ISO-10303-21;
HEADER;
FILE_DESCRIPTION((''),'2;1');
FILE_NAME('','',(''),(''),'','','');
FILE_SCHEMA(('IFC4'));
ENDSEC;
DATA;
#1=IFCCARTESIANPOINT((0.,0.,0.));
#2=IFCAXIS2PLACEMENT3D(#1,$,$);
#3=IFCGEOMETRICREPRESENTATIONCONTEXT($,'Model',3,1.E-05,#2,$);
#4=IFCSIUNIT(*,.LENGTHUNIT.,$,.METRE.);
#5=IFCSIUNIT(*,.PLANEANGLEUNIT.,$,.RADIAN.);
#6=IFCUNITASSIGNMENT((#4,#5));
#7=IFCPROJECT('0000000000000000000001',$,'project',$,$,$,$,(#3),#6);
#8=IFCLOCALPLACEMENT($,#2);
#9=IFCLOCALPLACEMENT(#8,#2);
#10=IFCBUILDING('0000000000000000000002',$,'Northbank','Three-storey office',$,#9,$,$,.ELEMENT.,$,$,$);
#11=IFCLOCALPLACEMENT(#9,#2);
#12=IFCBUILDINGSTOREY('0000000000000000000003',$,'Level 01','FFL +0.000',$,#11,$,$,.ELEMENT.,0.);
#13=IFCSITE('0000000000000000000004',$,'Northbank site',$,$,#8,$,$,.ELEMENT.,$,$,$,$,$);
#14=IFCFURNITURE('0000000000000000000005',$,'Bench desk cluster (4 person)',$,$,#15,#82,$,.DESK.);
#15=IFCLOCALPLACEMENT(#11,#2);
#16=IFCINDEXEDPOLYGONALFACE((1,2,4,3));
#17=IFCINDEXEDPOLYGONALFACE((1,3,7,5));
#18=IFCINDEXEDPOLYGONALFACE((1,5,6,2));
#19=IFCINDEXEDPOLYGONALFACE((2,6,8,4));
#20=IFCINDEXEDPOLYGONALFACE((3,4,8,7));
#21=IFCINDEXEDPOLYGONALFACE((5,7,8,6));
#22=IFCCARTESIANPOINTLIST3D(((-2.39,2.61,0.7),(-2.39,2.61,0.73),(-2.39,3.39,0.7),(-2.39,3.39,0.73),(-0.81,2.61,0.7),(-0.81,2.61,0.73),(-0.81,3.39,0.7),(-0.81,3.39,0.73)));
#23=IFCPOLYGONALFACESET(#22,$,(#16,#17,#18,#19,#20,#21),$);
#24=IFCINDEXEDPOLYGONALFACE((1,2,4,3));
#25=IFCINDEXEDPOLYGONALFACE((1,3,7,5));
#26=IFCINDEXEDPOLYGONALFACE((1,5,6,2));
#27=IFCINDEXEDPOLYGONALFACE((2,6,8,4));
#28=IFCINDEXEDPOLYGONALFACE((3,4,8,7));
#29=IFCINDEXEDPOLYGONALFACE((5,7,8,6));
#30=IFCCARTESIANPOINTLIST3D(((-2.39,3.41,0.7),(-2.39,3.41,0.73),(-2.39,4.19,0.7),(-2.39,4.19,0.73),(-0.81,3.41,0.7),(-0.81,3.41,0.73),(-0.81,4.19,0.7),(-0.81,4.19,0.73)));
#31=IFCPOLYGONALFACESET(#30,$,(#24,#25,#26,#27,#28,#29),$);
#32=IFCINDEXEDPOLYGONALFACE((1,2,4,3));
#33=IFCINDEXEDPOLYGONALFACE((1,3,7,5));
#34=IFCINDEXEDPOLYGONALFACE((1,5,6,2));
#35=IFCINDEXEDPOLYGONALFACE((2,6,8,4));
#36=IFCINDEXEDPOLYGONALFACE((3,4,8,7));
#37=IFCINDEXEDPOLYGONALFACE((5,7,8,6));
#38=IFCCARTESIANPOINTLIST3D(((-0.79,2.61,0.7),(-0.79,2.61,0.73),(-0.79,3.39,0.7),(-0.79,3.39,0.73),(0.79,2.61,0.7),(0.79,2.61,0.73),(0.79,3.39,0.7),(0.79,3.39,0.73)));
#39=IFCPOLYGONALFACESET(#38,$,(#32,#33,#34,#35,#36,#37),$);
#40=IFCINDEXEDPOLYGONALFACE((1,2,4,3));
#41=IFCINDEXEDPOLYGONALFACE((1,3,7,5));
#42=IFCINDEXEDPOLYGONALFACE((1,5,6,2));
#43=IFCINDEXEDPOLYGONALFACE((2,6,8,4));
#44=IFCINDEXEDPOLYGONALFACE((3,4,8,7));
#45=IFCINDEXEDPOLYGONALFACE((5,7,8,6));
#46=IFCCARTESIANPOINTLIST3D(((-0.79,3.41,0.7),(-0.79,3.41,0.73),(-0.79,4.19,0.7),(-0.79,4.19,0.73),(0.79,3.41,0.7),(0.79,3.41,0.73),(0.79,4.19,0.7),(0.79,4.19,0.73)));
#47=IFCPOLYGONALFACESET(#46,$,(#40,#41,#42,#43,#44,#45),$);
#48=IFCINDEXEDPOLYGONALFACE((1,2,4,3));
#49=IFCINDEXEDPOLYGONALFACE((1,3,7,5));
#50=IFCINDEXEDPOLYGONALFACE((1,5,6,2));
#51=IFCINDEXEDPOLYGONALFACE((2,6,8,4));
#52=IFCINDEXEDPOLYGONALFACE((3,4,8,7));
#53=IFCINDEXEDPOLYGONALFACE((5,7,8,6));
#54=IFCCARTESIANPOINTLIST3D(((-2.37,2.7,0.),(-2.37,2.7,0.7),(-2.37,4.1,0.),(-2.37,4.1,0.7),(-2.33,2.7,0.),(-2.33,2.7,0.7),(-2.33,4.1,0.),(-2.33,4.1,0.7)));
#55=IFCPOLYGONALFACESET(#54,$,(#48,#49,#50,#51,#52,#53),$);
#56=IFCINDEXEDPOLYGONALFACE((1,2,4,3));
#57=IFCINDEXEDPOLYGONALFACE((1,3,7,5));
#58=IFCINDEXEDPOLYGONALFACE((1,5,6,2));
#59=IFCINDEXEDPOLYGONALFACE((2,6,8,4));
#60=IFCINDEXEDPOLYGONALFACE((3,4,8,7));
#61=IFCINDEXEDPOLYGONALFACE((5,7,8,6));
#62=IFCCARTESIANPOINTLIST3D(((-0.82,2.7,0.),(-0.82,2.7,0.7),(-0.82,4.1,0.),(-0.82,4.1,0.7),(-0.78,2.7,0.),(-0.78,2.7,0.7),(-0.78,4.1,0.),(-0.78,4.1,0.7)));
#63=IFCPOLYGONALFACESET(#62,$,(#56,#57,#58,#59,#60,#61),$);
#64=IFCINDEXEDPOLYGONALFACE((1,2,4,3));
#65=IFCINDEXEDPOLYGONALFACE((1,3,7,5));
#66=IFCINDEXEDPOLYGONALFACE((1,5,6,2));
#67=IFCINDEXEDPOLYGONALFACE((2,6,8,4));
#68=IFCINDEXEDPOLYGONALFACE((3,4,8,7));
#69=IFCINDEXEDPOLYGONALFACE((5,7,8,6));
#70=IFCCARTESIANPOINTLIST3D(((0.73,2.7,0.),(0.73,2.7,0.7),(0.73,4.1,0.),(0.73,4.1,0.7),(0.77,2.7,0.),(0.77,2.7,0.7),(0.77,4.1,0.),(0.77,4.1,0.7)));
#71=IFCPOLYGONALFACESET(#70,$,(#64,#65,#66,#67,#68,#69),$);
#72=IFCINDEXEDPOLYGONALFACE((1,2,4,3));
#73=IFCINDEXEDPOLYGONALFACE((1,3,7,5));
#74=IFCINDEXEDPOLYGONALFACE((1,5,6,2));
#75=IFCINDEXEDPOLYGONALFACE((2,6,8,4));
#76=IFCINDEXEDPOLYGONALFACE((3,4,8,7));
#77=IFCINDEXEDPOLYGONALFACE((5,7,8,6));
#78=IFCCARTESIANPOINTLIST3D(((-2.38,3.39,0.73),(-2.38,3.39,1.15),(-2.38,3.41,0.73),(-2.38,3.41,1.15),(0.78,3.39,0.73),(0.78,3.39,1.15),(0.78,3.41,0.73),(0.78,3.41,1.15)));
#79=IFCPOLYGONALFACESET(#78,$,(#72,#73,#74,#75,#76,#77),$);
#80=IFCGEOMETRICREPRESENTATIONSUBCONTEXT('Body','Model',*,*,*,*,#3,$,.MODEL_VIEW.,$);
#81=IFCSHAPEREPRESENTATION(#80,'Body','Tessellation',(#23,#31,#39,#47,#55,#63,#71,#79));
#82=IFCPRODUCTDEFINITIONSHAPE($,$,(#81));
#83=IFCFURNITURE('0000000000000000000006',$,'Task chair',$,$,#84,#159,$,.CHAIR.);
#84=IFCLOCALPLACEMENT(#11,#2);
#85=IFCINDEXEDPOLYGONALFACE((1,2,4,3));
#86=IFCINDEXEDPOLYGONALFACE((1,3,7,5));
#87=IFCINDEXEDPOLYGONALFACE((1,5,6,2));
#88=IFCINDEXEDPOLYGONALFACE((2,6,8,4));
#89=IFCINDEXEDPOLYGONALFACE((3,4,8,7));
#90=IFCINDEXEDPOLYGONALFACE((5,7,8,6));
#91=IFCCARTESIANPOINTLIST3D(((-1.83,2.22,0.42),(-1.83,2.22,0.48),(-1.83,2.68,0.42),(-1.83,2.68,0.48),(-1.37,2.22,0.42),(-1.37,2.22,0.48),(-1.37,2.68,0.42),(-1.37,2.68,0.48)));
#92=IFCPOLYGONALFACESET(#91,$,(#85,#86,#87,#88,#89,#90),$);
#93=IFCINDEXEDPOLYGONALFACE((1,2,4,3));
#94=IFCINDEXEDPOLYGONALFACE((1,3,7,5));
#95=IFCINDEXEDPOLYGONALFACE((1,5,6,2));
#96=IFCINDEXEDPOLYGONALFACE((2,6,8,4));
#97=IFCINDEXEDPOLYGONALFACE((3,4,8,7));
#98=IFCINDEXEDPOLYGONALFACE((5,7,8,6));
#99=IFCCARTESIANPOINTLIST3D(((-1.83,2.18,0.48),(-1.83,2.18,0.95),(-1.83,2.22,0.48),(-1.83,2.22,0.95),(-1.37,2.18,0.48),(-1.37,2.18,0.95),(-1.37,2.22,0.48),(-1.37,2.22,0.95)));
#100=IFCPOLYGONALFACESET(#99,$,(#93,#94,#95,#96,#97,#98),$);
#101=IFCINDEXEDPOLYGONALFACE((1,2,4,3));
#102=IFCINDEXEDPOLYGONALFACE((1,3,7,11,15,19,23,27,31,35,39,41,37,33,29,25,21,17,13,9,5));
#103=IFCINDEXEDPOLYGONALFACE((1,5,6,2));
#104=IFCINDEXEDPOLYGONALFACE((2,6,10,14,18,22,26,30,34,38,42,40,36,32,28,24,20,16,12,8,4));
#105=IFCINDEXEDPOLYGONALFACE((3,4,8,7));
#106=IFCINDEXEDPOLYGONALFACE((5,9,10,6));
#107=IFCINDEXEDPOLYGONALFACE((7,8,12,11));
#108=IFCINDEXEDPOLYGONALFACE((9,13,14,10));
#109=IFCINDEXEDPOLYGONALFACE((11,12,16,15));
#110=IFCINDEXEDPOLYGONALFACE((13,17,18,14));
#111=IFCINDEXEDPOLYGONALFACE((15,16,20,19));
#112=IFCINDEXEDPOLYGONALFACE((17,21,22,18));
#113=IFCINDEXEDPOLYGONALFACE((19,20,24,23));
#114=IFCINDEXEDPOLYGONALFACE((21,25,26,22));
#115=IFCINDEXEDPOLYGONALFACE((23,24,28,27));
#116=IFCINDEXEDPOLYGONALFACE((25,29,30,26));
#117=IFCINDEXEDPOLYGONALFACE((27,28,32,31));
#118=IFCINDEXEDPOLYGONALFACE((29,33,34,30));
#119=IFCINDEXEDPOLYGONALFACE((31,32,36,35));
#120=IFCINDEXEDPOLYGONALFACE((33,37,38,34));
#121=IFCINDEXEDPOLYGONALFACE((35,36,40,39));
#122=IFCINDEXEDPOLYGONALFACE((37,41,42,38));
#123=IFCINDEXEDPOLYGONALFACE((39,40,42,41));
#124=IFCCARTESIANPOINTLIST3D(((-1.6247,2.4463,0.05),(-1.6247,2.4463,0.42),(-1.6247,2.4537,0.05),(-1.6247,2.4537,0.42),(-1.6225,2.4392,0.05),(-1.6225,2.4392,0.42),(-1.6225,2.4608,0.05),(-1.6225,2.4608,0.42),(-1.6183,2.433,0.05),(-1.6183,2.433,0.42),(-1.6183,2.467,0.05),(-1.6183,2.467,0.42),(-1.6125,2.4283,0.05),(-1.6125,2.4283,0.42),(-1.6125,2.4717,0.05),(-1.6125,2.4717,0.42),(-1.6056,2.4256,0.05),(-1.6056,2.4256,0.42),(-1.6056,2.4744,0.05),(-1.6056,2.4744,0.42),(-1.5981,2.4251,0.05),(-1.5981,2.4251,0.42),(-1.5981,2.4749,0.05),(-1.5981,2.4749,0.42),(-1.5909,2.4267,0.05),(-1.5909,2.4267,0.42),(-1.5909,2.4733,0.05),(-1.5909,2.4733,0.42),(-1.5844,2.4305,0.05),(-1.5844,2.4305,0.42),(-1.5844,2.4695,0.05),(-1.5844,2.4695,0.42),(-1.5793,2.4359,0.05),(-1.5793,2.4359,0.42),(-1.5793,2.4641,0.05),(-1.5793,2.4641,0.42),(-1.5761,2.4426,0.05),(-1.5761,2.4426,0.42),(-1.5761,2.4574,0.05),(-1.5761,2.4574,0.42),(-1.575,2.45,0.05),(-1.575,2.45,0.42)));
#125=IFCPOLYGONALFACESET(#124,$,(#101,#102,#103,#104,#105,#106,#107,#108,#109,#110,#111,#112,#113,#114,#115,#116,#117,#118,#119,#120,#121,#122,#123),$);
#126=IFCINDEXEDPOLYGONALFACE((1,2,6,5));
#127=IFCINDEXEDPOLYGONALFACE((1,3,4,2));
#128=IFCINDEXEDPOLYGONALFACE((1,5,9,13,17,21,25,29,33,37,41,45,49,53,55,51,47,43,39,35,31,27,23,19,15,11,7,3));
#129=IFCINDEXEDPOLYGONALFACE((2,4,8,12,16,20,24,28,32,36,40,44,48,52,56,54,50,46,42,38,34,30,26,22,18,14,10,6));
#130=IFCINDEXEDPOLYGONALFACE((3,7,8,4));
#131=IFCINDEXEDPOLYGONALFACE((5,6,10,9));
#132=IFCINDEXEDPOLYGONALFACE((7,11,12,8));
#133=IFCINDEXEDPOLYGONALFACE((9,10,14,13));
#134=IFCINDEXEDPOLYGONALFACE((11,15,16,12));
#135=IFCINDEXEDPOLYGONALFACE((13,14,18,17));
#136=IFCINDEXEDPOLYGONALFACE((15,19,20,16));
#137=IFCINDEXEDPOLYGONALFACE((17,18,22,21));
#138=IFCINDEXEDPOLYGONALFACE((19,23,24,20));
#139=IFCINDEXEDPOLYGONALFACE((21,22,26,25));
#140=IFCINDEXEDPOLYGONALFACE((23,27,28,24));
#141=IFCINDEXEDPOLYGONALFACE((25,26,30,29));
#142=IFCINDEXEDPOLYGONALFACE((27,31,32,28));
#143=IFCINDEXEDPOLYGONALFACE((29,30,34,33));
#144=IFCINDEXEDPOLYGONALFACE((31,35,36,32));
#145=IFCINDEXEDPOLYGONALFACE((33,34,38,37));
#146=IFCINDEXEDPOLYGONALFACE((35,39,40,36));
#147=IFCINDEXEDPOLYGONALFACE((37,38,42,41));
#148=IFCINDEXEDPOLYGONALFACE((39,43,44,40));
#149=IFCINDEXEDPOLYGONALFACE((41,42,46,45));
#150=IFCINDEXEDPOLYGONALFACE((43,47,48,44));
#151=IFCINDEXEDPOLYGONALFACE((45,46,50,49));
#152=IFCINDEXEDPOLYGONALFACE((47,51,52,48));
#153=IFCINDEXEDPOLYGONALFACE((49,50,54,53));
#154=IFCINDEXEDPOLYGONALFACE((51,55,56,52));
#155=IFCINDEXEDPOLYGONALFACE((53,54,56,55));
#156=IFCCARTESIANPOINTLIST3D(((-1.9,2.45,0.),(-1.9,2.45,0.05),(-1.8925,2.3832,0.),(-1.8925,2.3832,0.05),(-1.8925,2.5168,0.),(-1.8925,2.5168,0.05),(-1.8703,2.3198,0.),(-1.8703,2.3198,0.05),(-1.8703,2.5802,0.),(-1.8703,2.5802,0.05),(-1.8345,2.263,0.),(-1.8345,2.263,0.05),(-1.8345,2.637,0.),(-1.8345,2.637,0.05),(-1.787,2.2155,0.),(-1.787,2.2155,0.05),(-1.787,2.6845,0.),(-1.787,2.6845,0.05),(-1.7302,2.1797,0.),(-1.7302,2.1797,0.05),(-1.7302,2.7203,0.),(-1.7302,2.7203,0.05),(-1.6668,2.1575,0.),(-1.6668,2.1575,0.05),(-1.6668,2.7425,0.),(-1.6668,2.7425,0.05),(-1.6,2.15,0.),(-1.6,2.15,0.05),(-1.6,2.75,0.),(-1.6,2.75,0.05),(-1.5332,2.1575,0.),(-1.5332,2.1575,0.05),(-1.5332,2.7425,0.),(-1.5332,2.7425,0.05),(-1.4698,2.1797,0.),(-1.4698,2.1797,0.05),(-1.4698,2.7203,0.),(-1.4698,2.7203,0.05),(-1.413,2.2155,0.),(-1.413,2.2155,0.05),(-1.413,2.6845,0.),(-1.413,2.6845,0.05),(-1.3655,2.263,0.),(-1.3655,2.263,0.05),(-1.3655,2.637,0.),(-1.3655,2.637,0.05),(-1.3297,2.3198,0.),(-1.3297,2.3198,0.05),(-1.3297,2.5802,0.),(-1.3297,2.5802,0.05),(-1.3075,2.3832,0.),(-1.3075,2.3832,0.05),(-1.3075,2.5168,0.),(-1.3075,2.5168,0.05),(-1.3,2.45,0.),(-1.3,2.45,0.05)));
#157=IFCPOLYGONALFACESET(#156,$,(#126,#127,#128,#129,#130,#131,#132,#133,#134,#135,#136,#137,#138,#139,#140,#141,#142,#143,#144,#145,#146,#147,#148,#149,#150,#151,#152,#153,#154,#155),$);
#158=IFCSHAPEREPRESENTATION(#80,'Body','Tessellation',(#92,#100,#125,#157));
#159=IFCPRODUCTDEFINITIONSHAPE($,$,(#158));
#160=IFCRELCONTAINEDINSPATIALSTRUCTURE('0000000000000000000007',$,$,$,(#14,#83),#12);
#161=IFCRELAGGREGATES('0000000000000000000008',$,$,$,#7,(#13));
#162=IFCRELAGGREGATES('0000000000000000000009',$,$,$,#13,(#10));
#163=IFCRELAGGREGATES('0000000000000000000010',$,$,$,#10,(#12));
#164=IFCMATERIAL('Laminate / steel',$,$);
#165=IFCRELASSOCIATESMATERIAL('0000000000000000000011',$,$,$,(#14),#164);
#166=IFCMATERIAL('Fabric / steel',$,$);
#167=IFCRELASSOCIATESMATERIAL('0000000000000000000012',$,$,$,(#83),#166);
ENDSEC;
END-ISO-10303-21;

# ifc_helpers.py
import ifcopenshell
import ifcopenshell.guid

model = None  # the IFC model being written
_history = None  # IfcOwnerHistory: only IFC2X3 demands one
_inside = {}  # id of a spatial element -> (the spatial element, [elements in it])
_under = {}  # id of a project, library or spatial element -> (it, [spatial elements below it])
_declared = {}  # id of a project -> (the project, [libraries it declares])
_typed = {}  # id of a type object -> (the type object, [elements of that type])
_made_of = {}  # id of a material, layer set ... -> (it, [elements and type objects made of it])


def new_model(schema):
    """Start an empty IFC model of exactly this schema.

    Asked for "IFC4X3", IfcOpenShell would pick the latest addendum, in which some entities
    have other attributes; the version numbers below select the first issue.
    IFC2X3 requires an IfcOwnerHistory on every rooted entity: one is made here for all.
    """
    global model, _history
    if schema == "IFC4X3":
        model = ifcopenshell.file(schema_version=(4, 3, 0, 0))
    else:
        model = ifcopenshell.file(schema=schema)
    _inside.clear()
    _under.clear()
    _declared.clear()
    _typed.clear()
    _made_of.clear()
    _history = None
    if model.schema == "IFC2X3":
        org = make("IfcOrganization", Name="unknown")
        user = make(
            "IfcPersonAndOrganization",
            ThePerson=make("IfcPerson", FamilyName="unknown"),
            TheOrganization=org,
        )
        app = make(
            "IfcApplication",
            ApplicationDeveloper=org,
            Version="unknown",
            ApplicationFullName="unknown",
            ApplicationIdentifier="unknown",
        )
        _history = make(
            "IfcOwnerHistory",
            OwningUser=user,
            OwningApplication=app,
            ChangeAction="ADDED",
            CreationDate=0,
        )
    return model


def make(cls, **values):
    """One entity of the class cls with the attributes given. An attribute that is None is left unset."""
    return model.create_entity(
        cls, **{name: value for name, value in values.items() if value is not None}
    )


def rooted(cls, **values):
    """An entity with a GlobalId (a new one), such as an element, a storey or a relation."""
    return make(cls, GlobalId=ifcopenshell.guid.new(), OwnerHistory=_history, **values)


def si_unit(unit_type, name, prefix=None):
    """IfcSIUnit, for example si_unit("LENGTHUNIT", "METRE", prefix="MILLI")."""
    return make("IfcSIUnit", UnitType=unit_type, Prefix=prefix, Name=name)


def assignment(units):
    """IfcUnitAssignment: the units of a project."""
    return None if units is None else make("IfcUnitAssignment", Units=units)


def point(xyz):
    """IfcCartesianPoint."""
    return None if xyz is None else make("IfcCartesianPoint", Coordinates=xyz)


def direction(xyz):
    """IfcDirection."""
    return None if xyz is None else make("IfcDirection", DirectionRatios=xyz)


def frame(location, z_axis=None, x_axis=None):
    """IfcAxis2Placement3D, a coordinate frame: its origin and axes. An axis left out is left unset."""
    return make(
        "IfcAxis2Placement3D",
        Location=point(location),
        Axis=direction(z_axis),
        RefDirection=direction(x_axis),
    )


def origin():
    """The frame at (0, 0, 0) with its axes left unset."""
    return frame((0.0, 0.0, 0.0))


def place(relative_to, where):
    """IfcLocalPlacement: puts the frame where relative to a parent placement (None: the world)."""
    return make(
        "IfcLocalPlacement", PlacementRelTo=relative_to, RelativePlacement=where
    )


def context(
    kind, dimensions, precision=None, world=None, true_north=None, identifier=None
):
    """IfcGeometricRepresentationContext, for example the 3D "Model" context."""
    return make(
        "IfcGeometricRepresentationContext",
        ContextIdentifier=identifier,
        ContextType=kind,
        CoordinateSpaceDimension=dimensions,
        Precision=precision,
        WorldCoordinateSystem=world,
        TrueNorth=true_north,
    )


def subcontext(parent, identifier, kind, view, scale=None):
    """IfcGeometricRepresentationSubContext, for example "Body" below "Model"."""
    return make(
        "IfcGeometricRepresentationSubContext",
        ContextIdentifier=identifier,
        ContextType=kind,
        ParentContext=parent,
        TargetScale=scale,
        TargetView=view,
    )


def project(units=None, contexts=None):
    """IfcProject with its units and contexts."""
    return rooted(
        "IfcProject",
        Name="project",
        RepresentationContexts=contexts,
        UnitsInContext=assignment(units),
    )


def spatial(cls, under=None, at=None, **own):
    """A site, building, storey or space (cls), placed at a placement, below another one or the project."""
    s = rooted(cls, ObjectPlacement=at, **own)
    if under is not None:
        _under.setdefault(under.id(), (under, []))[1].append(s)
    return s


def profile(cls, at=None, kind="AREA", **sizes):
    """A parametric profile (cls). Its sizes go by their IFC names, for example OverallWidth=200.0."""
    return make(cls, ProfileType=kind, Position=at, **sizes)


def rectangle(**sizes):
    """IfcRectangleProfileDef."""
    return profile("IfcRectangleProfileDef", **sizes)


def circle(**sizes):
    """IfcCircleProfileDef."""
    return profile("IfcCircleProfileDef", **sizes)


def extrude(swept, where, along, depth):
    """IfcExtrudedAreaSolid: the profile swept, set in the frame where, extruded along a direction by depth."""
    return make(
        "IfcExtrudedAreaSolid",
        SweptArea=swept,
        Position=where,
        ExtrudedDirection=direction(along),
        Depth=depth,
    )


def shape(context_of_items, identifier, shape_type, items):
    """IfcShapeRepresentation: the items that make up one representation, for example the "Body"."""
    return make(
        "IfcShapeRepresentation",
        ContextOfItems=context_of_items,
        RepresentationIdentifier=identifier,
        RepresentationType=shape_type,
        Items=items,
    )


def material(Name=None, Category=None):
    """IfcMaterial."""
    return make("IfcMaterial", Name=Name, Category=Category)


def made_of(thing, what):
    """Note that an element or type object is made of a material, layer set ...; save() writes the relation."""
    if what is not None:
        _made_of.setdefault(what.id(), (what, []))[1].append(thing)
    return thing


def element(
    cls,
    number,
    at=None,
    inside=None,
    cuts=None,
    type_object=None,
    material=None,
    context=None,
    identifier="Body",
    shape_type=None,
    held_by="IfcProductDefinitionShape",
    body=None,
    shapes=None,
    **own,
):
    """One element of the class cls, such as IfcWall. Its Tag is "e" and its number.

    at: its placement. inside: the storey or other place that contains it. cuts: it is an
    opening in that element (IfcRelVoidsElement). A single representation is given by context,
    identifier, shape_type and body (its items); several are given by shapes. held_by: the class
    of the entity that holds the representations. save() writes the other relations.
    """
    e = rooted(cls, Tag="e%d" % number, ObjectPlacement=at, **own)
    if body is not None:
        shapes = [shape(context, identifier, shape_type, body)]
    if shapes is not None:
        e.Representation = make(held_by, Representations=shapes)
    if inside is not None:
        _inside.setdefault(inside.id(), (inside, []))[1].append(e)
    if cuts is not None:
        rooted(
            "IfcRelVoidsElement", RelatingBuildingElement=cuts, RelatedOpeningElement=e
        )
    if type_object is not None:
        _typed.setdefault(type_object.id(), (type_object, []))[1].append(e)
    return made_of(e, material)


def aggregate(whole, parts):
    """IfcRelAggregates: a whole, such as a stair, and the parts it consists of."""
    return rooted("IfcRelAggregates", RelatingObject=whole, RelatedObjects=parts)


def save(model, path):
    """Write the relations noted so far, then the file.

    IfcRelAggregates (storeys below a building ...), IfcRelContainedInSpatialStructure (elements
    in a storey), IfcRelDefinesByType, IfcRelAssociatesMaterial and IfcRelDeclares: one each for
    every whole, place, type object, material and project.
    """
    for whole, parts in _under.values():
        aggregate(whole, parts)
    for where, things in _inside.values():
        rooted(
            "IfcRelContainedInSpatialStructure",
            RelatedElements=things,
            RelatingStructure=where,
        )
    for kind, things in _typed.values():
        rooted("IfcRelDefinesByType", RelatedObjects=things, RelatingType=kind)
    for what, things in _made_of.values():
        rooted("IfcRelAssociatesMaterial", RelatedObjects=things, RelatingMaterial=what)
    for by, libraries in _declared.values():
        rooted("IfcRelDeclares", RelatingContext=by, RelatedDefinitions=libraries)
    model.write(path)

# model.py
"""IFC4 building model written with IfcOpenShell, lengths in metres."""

from ifc_helpers import new_model, si_unit, frame, origin, place, context, subcontext, project, spatial, rectangle, circle, extrude, material, element, save


model = new_model("IFC4")

# Units and contexts
model_context = context("Model", 3, precision=1e-05, world=origin())
body_context = subcontext(model_context, "Body", "Model", "MODEL_VIEW")
ifc_project = project(units=[si_unit("LENGTHUNIT", "METRE"), si_unit("PLANEANGLEUNIT", "RADIAN")], contexts=[model_context])

# Site, building, storey
site_placement = place(None, origin())
site = spatial("IfcSite", under=ifc_project, at=site_placement, Name="Northbank site", CompositionType="ELEMENT")
building_placement = place(site_placement, origin())
building = spatial("IfcBuilding", under=site, at=building_placement, Name="Northbank", Description="Three-storey office", CompositionType="ELEMENT")
storey_placement = place(building_placement, origin())
storey = spatial("IfcBuildingStorey", under=building, at=storey_placement, Name="Level 01", Description="FFL +0.000", CompositionType="ELEMENT", Elevation=0.0)

# Furniture
ifc_material_1 = material(Name="Laminate / steel")
ifc_material_2 = material(Name="Fabric / steel")
furniture_1_placement = place(storey_placement, origin())
element("IfcFurniture", 1, at=furniture_1_placement, inside=storey, material=ifc_material_1, Name="Bench desk cluster (4 person)", PredefinedType="DESK", context=body_context, shape_type="SweptSolid", body=[
    extrude(rectangle(XDim=1.58, YDim=0.78), frame((-1.6, 3.0, 0.7)), (0.0, 0.0, 1.0), 0.03),
    extrude(rectangle(XDim=1.58, YDim=0.78), frame((-1.6, 3.8, 0.7)), (0.0, 0.0, 1.0), 0.03),
    extrude(rectangle(XDim=1.58, YDim=0.78), frame((0.0, 3.0, 0.7)), (0.0, 0.0, 1.0), 0.03),
    extrude(rectangle(XDim=1.58, YDim=0.78), frame((0.0, 3.8, 0.7)), (0.0, 0.0, 1.0), 0.03),
    extrude(rectangle(XDim=0.04, YDim=1.4), frame((-2.35, 3.4, 0.0)), (0.0, 0.0, 1.0), 0.7),
    extrude(rectangle(XDim=0.04, YDim=1.4), frame((-0.8, 3.4, 0.0)), (0.0, 0.0, 1.0), 0.7),
    extrude(rectangle(XDim=0.04, YDim=1.4), frame((0.75, 3.4, 0.0)), (0.0, 0.0, 1.0), 0.7),
    extrude(rectangle(XDim=3.16, YDim=0.02), frame((-0.8, 3.4, 0.73)), (0.0, 0.0, 1.0), 0.42),
])
furniture_2_placement = place(storey_placement, origin())
element("IfcFurniture", 2, at=furniture_2_placement, inside=storey, material=ifc_material_2, Name="Task chair", PredefinedType="CHAIR", context=body_context, shape_type="SweptSolid", body=[
    extrude(rectangle(XDim=0.46, YDim=0.46), frame((-1.6, 2.45, 0.42)), (0.0, 0.0, 1.0), 0.06),
    extrude(rectangle(XDim=0.46, YDim=0.04), frame((-1.6, 2.2, 0.48)), (0.0, 0.0, 1.0), 0.47),
    extrude(circle(Radius=0.025), frame((-1.6, 2.45, 0.05), z_axis=(0.0, 0.0, 1.0), x_axis=(1.0, 0.0, 0.0)), (0.0, 0.0, 1.0), 0.37),
    extrude(circle(Radius=0.3), frame((-1.6, 2.45, 0.0), z_axis=(0.0, 0.0, 1.0), x_axis=(1.0, 0.0, 0.0)), (0.0, 0.0, 1.0), 0.05),
])

save(model, "model.ifc")
